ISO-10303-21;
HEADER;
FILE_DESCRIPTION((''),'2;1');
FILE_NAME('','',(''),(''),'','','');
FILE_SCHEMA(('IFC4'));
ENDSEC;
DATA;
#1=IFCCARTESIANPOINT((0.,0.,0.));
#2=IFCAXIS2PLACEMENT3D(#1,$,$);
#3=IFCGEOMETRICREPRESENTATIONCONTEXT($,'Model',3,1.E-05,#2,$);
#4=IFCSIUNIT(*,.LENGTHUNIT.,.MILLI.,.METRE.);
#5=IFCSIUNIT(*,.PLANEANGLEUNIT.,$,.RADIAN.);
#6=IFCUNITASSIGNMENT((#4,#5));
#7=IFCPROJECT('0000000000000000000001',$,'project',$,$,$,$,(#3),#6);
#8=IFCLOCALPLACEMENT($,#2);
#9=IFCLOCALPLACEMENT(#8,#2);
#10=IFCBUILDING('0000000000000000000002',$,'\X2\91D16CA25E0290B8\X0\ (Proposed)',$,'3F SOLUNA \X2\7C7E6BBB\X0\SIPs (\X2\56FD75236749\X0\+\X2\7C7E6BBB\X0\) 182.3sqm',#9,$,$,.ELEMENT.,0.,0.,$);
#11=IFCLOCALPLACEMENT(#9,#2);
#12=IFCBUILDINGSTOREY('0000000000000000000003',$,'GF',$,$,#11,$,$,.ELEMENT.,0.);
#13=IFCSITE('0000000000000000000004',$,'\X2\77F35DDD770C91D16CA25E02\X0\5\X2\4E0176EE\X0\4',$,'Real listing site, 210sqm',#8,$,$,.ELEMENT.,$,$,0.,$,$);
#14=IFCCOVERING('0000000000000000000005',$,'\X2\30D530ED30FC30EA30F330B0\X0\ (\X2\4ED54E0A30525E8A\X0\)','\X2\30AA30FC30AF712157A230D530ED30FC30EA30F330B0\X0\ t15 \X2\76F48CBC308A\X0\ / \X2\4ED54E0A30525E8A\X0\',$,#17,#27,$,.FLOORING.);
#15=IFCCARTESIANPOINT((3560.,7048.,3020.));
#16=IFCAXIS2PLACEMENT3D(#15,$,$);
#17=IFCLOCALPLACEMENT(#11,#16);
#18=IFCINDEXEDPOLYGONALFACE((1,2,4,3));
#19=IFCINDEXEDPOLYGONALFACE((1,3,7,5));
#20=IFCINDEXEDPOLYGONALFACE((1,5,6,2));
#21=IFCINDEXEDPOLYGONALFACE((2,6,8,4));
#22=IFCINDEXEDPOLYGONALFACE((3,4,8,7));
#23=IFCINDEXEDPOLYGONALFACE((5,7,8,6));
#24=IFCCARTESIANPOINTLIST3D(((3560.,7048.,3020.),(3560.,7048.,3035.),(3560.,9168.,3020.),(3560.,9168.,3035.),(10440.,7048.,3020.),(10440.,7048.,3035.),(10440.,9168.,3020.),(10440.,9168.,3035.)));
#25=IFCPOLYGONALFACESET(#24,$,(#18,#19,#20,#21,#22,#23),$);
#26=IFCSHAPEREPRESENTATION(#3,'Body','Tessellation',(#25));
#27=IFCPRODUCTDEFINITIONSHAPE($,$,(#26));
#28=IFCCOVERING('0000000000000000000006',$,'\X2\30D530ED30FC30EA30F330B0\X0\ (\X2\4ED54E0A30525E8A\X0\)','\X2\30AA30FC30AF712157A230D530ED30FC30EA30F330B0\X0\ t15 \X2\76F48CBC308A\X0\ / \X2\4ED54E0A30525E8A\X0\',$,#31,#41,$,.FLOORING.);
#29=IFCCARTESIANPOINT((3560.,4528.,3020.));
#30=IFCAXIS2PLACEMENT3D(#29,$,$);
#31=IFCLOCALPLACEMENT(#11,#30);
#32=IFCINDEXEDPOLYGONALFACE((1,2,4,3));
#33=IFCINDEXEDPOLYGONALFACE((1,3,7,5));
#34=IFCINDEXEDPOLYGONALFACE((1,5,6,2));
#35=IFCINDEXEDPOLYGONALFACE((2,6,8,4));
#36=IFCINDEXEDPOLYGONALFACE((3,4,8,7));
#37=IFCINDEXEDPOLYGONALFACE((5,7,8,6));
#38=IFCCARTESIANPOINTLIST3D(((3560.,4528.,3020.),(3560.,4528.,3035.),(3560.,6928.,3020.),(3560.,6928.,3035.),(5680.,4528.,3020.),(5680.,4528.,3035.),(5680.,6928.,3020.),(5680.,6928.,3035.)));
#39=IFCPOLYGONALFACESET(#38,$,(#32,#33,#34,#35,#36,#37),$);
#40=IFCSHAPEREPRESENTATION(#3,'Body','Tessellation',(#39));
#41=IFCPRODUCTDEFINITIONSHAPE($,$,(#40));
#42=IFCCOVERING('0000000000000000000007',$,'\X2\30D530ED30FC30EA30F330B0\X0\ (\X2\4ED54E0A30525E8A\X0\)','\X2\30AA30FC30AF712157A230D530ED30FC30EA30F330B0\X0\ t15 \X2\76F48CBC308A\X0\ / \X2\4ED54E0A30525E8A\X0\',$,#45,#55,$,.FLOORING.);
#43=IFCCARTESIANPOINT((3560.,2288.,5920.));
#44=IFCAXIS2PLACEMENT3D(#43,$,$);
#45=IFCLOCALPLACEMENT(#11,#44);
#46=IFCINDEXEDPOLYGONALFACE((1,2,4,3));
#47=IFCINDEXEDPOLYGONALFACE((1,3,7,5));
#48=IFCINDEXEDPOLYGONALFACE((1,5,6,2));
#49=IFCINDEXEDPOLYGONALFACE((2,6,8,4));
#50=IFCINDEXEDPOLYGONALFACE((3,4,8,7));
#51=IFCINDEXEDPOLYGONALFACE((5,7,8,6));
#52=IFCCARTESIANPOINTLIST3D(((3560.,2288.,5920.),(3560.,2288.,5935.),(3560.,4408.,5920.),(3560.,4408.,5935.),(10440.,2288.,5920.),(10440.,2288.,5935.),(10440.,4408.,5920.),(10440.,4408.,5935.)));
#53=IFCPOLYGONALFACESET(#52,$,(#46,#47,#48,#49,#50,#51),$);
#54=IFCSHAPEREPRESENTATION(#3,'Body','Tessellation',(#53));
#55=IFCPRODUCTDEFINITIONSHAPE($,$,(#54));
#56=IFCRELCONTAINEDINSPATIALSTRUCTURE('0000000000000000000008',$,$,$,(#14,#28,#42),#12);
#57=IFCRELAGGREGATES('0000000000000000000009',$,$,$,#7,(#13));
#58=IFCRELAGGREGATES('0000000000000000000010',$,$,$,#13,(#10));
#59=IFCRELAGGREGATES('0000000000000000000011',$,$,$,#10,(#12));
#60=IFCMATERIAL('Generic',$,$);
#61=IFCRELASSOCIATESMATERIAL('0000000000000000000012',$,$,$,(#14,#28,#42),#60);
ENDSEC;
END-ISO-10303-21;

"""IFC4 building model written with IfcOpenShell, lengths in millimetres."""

from ifc_helpers import new_model, si_unit, frame, frame_2d, origin, place, context, project, spatial, rectangle, extrude, material, element, save


model = new_model("IFC4")

# Units and contexts
model_context = context("Model", 3, precision=1e-05, world=origin())
ifc_project = project(units=[si_unit("LENGTHUNIT", "METRE", prefix="MILLI"), si_unit("PLANEANGLEUNIT", "RADIAN")], contexts=[model_context])

# Site, building, storey
site_placement = place(None, origin())
site = spatial("IfcSite", under=ifc_project, at=site_placement, Name="石川県金沢市5丁目4", ObjectType="Real listing site, 210sqm", CompositionType="ELEMENT", RefElevation=0.0)
building_placement = place(site_placement, origin())
building = spatial("IfcBuilding", under=site, at=building_placement, Name="金沢市邸 (Proposed)", ObjectType="3F SOLUNA 籾殻SIPs (国産杉+籾殻) 182.3sqm", CompositionType="ELEMENT", ElevationOfRefHeight=0.0, ElevationOfTerrain=0.0)
storey_placement = place(building_placement, origin())
storey = spatial("IfcBuildingStorey", under=building, at=storey_placement, Name="GF", CompositionType="ELEMENT", Elevation=0.0)

# Shared definitions
ifc_material_1 = material(Name="Generic")

# Coverings
covering_1_placement = place(storey_placement, frame((3560.0, 7048.0, 3020.0)))
element("IfcCovering", 1, at=covering_1_placement, inside=storey, material=ifc_material_1, Name="フローリング (仕上げ床)", Description="オーク無垢フローリング t15 直貼り / 仕上げ床", PredefinedType="FLOORING", context=model_context, shape_type="SweptSolid", body=[
    extrude(rectangle(XDim=6880.0, YDim=2120.0, at=frame_2d((3440.0, 1060.0))), frame((3560.0, 7048.0, 3020.0)), (0.0, 0.0, 1.0), 15.0),
])
covering_2_placement = place(storey_placement, frame((3560.0, 4528.0, 3020.0)))
element("IfcCovering", 2, at=covering_2_placement, inside=storey, material=ifc_material_1, Name="フローリング (仕上げ床)", Description="オーク無垢フローリング t15 直貼り / 仕上げ床", PredefinedType="FLOORING", context=model_context, shape_type="SweptSolid", body=[
    extrude(rectangle(XDim=2120.0, YDim=2400.0, at=frame_2d((1060.0, 1200.0))), frame((3560.0, 4528.0, 3020.0)), (0.0, 0.0, 1.0), 15.0),
])
covering_3_placement = place(storey_placement, frame((3560.0, 2288.0, 5920.0)))
element("IfcCovering", 3, at=covering_3_placement, inside=storey, material=ifc_material_1, Name="フローリング (仕上げ床)", Description="オーク無垢フローリング t15 直貼り / 仕上げ床", PredefinedType="FLOORING", context=model_context, shape_type="SweptSolid", body=[
    extrude(rectangle(XDim=6880.0, YDim=2120.0, at=frame_2d((3440.0, 1060.0))), frame((3560.0, 2288.0, 5920.0)), (0.0, 0.0, 1.0), 15.0),
])

save(model, "model.ifc")
